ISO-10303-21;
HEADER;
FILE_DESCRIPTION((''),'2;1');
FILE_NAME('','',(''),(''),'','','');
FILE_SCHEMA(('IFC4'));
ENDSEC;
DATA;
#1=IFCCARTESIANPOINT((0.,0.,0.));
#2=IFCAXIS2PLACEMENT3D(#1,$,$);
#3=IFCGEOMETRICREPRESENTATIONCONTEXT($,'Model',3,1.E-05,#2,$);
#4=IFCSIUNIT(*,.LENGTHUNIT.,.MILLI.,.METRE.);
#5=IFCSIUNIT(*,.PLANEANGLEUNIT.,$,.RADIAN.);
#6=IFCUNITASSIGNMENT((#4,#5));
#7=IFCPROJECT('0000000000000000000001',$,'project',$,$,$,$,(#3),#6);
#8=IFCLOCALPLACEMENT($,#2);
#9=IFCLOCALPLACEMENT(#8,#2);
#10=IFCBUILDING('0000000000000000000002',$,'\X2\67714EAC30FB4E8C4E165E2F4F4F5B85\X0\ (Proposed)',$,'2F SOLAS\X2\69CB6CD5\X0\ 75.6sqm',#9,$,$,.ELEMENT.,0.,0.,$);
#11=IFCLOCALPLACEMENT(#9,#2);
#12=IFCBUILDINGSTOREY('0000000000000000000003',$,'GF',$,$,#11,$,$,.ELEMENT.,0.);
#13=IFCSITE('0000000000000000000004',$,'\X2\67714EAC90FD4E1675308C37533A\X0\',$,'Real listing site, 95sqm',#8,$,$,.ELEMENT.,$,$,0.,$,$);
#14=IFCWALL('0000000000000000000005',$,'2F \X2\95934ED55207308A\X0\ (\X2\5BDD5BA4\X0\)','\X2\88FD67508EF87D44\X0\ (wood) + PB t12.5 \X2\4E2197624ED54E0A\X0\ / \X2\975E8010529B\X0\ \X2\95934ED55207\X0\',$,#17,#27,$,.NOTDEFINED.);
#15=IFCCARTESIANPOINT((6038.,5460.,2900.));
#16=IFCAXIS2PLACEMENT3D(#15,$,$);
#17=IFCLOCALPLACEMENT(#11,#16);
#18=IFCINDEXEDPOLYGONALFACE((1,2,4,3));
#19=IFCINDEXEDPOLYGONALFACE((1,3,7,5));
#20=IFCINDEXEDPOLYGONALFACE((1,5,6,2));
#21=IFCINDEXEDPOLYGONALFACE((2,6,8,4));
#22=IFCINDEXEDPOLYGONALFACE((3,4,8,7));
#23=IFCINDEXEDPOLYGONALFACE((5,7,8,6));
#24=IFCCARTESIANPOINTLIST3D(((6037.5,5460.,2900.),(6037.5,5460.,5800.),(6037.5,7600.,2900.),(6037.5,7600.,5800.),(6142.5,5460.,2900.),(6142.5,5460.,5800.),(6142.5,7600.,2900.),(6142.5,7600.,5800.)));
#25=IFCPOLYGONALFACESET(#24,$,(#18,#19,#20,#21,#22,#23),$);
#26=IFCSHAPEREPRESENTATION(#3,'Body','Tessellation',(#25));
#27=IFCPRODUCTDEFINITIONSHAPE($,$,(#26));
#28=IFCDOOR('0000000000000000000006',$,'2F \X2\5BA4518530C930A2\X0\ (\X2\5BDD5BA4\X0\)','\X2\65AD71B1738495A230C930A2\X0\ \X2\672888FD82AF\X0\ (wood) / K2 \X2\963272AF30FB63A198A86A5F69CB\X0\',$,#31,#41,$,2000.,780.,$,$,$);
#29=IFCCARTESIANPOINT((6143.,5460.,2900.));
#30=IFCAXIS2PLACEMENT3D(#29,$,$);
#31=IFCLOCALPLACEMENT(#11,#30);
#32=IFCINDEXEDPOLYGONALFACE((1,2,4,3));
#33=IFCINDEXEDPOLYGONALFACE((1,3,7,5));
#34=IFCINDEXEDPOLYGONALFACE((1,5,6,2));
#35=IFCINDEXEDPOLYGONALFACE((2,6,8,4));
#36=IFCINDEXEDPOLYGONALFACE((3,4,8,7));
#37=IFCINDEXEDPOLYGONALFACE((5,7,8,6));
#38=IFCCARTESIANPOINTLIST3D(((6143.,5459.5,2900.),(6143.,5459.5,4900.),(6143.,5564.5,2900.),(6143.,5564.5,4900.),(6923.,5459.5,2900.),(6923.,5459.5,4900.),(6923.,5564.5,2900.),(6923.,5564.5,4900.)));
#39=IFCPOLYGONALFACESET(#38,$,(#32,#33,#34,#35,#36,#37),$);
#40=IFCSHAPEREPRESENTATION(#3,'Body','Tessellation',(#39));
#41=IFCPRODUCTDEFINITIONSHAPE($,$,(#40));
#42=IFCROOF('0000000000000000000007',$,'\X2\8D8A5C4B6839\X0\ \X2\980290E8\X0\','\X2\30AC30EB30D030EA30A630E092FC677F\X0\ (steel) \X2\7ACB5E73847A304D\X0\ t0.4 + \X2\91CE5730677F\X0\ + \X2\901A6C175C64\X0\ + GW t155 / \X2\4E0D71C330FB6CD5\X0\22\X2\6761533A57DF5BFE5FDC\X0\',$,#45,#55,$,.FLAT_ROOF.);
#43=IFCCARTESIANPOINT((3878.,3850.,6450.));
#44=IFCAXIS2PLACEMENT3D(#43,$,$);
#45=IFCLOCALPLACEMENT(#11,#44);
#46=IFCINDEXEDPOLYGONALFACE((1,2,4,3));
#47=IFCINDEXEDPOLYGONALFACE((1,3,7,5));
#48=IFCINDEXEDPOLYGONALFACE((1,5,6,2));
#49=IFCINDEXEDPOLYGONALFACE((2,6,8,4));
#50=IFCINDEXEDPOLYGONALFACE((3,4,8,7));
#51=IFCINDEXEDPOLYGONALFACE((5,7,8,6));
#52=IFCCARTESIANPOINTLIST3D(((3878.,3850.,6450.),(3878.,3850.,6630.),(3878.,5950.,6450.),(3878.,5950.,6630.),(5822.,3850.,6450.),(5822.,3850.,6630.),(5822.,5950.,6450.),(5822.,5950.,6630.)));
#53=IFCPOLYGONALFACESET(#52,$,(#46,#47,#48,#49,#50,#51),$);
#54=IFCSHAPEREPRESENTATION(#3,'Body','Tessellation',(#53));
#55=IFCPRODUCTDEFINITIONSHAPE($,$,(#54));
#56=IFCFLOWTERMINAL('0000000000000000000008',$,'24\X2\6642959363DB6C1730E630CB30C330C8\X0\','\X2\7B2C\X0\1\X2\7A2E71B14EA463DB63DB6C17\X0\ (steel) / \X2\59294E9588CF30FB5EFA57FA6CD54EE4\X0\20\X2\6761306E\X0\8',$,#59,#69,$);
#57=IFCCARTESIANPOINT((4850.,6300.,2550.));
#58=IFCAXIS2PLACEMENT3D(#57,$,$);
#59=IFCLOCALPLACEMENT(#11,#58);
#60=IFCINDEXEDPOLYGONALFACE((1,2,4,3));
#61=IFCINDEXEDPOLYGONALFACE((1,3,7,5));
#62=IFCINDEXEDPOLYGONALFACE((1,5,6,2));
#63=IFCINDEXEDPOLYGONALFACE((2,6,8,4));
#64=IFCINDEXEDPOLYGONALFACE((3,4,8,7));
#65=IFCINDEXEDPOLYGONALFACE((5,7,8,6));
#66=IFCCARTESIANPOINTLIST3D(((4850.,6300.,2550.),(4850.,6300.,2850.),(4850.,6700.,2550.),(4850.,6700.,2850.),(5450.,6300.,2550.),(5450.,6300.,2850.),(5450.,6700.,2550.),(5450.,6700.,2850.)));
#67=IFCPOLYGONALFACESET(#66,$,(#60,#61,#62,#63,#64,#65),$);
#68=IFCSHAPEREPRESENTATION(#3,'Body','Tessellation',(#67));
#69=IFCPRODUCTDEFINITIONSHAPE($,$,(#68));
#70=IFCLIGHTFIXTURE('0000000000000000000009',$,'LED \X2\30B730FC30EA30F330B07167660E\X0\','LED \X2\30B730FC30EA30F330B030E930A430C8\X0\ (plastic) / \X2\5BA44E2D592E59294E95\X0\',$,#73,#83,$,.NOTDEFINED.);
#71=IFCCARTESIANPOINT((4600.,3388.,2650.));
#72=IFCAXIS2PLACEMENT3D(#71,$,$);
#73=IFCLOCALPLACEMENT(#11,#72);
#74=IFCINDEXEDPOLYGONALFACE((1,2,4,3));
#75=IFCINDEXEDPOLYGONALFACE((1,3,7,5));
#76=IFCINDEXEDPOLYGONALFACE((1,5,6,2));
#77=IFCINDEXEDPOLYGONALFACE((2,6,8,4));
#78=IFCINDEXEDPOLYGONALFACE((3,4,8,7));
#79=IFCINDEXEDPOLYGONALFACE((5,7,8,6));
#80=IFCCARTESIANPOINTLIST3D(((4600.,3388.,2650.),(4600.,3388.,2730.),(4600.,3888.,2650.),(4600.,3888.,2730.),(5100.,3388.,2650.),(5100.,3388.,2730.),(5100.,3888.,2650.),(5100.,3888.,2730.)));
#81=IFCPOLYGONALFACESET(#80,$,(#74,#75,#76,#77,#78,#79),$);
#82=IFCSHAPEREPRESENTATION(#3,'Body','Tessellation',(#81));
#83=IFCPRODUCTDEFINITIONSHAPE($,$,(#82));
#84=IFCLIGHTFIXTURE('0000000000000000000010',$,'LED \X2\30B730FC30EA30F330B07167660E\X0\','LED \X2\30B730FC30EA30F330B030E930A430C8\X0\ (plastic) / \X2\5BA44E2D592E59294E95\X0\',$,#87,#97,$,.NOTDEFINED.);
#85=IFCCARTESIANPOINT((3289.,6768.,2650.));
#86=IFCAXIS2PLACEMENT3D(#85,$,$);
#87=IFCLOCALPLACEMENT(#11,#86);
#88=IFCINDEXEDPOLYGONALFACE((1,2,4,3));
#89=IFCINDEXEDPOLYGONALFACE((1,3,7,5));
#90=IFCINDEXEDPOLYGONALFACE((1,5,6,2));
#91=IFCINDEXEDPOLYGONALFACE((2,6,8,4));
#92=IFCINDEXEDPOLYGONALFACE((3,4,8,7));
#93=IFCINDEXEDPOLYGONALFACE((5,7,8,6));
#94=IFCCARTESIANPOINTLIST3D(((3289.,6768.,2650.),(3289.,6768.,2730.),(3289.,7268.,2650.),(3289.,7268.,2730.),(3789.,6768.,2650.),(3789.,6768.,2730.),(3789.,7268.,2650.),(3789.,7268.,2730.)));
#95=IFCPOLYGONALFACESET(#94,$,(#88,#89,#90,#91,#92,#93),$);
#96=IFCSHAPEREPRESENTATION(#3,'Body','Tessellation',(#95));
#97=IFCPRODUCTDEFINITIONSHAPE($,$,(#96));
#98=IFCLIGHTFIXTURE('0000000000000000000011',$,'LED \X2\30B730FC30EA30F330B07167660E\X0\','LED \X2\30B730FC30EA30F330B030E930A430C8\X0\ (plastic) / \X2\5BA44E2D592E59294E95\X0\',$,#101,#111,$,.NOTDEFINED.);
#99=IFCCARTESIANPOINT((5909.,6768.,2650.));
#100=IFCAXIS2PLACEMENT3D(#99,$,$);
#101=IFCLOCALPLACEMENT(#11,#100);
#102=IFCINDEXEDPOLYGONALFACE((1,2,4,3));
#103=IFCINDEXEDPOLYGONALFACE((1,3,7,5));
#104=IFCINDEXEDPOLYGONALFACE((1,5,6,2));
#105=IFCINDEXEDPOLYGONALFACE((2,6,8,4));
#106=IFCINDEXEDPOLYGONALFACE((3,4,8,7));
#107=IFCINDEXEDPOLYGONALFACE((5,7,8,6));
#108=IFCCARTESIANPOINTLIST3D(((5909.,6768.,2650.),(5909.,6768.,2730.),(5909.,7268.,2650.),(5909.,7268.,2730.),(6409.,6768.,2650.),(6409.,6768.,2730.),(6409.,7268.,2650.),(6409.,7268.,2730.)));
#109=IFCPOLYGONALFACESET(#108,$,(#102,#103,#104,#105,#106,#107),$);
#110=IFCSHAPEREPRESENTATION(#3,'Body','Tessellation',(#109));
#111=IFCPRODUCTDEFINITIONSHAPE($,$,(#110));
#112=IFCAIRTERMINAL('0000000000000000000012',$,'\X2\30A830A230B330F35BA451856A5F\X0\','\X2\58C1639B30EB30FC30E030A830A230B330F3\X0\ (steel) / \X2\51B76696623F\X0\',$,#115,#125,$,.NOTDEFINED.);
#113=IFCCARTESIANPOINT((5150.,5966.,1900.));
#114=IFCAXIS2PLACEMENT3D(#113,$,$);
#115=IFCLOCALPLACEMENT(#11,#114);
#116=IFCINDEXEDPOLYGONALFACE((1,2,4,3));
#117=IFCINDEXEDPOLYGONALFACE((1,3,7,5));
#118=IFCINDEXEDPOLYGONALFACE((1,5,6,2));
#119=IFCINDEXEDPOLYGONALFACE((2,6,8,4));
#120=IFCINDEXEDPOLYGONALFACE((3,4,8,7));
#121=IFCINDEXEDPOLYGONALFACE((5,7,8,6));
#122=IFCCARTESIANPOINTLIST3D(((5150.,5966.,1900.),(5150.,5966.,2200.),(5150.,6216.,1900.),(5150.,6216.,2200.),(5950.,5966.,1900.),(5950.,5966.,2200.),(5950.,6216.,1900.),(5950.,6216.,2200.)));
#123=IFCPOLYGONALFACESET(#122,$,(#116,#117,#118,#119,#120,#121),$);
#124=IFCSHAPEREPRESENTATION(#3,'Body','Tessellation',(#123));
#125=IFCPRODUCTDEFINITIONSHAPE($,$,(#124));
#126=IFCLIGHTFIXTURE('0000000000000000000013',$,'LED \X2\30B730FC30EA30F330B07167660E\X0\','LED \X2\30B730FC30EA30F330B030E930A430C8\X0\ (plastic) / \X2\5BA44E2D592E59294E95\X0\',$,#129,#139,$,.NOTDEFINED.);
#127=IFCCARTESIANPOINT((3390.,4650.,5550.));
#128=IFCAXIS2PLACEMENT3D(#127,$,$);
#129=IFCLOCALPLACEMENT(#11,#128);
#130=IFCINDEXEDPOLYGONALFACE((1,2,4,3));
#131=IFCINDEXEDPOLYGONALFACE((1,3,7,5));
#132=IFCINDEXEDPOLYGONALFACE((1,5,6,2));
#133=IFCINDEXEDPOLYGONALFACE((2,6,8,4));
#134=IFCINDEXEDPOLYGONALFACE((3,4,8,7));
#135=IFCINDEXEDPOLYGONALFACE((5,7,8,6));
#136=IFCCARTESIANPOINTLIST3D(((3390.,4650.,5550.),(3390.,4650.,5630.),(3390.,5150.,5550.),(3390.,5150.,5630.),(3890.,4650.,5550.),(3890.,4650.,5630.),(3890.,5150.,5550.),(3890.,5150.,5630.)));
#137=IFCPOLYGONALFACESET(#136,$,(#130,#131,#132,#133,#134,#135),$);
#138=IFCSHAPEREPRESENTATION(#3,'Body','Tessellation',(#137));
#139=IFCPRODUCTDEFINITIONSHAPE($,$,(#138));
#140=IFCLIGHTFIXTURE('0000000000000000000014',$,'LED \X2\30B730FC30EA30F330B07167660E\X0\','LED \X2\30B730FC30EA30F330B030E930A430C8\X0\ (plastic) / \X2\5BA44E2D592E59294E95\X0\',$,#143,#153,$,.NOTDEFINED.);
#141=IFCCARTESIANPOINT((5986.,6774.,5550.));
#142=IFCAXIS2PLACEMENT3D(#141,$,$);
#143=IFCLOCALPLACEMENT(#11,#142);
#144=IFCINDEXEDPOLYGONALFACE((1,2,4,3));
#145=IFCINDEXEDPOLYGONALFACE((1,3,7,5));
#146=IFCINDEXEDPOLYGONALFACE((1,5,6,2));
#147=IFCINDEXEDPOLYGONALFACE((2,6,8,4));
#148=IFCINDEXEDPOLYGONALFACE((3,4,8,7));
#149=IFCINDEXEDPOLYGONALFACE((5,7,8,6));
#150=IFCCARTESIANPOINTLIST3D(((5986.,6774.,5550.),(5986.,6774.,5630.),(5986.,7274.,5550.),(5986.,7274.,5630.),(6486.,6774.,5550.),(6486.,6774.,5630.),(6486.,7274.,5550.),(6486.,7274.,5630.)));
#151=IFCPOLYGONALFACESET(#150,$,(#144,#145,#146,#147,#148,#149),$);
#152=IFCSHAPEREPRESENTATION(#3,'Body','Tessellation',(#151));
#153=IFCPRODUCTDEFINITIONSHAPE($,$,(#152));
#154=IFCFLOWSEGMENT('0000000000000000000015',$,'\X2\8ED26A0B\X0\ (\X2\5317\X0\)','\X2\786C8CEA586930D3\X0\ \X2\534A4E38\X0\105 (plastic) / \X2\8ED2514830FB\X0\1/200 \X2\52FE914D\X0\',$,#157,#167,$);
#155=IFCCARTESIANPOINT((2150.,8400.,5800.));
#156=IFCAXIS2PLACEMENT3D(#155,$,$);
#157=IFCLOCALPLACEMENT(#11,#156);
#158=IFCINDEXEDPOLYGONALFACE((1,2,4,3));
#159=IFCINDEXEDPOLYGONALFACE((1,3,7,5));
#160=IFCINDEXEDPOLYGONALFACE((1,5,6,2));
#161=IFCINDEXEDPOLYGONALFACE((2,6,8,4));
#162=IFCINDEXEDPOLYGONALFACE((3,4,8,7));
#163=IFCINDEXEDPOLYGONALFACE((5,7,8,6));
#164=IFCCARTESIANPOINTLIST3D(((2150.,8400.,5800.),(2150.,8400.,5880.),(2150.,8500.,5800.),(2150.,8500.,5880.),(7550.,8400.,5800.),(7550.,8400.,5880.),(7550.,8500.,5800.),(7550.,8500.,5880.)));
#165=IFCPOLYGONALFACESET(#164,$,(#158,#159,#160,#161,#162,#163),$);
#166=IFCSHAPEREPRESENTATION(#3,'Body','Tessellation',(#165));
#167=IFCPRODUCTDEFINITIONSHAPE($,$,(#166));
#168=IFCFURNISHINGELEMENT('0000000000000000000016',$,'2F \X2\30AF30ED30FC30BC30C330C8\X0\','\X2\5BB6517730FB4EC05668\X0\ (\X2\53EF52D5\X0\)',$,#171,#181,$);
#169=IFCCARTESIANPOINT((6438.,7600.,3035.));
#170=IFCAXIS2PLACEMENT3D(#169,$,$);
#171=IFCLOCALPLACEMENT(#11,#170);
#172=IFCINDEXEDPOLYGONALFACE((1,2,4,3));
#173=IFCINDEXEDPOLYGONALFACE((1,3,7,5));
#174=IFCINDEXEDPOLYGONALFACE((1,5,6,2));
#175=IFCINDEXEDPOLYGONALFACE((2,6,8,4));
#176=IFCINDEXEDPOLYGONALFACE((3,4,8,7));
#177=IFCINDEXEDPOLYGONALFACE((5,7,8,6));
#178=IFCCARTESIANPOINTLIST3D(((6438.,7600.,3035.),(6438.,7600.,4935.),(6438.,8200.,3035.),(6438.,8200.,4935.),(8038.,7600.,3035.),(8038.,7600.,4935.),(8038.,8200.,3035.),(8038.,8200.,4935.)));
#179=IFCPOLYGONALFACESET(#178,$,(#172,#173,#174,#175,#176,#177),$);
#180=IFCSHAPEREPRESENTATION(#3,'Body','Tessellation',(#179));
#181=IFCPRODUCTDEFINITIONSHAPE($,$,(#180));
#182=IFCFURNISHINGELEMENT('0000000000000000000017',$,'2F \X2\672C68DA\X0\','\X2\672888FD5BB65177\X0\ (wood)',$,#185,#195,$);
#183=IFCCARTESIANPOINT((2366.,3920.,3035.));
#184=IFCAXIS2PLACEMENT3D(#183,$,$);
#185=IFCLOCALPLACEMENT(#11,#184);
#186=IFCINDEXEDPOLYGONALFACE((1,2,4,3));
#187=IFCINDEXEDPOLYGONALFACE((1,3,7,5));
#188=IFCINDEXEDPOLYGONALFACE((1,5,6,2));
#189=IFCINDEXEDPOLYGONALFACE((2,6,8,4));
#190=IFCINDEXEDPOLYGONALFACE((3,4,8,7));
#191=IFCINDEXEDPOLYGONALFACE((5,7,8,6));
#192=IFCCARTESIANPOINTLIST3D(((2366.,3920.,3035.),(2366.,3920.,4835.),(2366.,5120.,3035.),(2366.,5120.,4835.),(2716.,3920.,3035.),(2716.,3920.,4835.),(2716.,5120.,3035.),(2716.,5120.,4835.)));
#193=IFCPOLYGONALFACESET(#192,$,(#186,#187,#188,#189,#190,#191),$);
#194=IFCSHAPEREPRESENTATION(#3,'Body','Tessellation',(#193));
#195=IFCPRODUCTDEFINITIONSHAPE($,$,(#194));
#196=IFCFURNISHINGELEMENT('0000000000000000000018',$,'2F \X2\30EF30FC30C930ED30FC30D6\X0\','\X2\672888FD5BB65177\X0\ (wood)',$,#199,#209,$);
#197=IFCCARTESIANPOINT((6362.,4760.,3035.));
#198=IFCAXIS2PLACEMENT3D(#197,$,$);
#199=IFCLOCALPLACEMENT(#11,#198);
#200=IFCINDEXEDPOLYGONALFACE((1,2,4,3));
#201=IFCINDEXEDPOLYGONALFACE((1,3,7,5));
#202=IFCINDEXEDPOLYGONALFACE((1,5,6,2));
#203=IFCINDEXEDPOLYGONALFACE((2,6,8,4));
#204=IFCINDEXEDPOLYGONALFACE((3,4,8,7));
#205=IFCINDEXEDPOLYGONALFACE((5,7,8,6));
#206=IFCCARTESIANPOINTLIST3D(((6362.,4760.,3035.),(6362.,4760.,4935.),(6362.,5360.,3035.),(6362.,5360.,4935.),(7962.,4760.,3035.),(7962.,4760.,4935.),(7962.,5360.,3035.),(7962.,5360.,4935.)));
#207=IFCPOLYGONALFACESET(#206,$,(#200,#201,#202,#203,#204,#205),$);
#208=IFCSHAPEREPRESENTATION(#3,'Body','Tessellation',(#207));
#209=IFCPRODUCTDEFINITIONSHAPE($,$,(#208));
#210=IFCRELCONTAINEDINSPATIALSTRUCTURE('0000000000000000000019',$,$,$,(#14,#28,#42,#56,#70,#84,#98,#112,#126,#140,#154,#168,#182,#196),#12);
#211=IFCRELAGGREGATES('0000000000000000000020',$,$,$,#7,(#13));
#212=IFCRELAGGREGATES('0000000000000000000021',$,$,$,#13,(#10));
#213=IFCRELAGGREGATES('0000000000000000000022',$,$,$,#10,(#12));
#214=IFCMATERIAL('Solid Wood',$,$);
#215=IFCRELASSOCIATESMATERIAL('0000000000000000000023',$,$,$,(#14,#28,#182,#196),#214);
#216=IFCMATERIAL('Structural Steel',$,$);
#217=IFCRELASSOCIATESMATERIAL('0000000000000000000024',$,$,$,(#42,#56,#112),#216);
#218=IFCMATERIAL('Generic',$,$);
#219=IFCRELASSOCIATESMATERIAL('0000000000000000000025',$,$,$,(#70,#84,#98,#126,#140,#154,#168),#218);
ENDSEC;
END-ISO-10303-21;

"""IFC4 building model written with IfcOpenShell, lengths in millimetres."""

from ifc_helpers import new_model, si_unit, frame, frame_2d, origin, place, context, project, spatial, rectangle, extrude, material, element, save


model = new_model("IFC4")

# Units and contexts
model_context = context("Model", 3, precision=1e-05, world=origin())
ifc_project = project(units=[si_unit("LENGTHUNIT", "METRE", prefix="MILLI"), si_unit("PLANEANGLEUNIT", "RADIAN")], contexts=[model_context])

# Site, building, storey
site_placement = place(None, origin())
site = spatial("IfcSite", under=ifc_project, at=site_placement, Name="東京都世田谷区", ObjectType="Real listing site, 95sqm", CompositionType="ELEMENT", RefElevation=0.0)
building_placement = place(site_placement, origin())
building = spatial("IfcBuilding", under=site, at=building_placement, Name="東京・二世帯住宅 (Proposed)", ObjectType="2F SOLAS構法 75.6sqm", CompositionType="ELEMENT", ElevationOfRefHeight=0.0, ElevationOfTerrain=0.0)
storey_placement = place(building_placement, origin())
storey = spatial("IfcBuildingStorey", under=building, at=storey_placement, Name="GF", CompositionType="ELEMENT", Elevation=0.0)

# Shared definitions
ifc_material_1 = material(Name="Solid Wood")

# Wall
wall_1_placement = place(storey_placement, frame((6038.0, 5460.0, 2900.0)))
element("IfcWall", 1, at=wall_1_placement, inside=storey, material=ifc_material_1, Name="2F 間仕切り (寝室)", Description="製材軸組 (wood) + PB t12.5 両面仕上 / 非耐力 間仕切", PredefinedType="NOTDEFINED", context=model_context, shape_type="SweptSolid", body=[
    extrude(rectangle(XDim=105.0, YDim=2140.0, at=frame_2d((52.0, 1070.0))), frame((6038.0, 5460.0, 2900.0)), (0.0, 0.0, 1.0), 2900.0),
])

# Door
door_placement = place(storey_placement, frame((6143.0, 5460.0, 2900.0)))
element("IfcDoor", 2, at=door_placement, inside=storey, material=ifc_material_1, Name="2F 室内ドア (寝室)", Description="断熱玄関ドア 木製芯 (wood) / K2 防犯・採風機構", OverallHeight=2000.0, OverallWidth=780.0, context=model_context, shape_type="SweptSolid", body=[
    extrude(rectangle(XDim=780.0, YDim=105.0, at=frame_2d((390.0, 52.0))), frame((6143.0, 5460.0, 2900.0)), (0.0, 0.0, 1.0), 2000.0),
])

# Roof
ifc_material_2 = material(Name="Structural Steel")
roof_placement = place(storey_placement, frame((3878.0, 3850.0, 6450.0)))
element("IfcRoof", 3, at=roof_placement, inside=storey, material=ifc_material_2, Name="越屋根 頂部", Description="ガルバリウム鋼板 (steel) 立平葺き t0.4 + 野地板 + 通気層 + GW t155 / 不燃・法22条区域対応", PredefinedType="FLAT_ROOF", context=model_context, shape_type="SweptSolid", body=[
    extrude(rectangle(XDim=1944.0, YDim=2100.0, at=frame_2d((972.0, 1050.0))), frame((3878.0, 3850.0, 6450.0)), (0.0, 0.0, 1.0), 180.0),
])

# Flow terminal
flow_terminal_placement = place(storey_placement, frame((4850.0, 6300.0, 2550.0)))
element("IfcFlowTerminal", 4, at=flow_terminal_placement, inside=storey, material=ifc_material_2, Name="24時間換気ユニット", Description="第1種熱交換換気 (steel) / 天井裏・建基法令20条の8", context=model_context, shape_type="SweptSolid", body=[
    extrude(rectangle(XDim=600.0, YDim=400.0, at=frame_2d((300.0, 200.0))), frame((4850.0, 6300.0, 2550.0)), (0.0, 0.0, 1.0), 300.0),
])

# Light fixtures
ifc_material_3 = material(Name="Generic")
light_fixture_1_placement = place(storey_placement, frame((4600.0, 3388.0, 2650.0)))
element("IfcLightFixture", 5, at=light_fixture_1_placement, inside=storey, material=ifc_material_3, Name="LED シーリング照明", Description="LED シーリングライト (plastic) / 室中央天井", PredefinedType="NOTDEFINED", context=model_context, shape_type="SweptSolid", body=[
    extrude(rectangle(XDim=500.0, YDim=500.0, at=frame_2d((250.0, 250.0))), frame((4600.0, 3388.0, 2650.0)), (0.0, 0.0, 1.0), 80.0),
])
light_fixture_2_placement = place(storey_placement, frame((3289.0, 6768.0, 2650.0)))
element("IfcLightFixture", 6, at=light_fixture_2_placement, inside=storey, material=ifc_material_3, Name="LED シーリング照明", Description="LED シーリングライト (plastic) / 室中央天井", PredefinedType="NOTDEFINED", context=model_context, shape_type="SweptSolid", body=[
    extrude(rectangle(XDim=500.0, YDim=500.0, at=frame_2d((250.0, 250.0))), frame((3289.0, 6768.0, 2650.0)), (0.0, 0.0, 1.0), 80.0),
])
light_fixture_3_placement = place(storey_placement, frame((5909.0, 6768.0, 2650.0)))
element("IfcLightFixture", 7, at=light_fixture_3_placement, inside=storey, material=ifc_material_3, Name="LED シーリング照明", Description="LED シーリングライト (plastic) / 室中央天井", PredefinedType="NOTDEFINED", context=model_context, shape_type="SweptSolid", body=[
    extrude(rectangle(XDim=500.0, YDim=500.0, at=frame_2d((250.0, 250.0))), frame((5909.0, 6768.0, 2650.0)), (0.0, 0.0, 1.0), 80.0),
])

# Air terminal
air_terminal_placement = place(storey_placement, frame((5150.0, 5966.0, 1900.0)))
element("IfcAirTerminal", 8, at=air_terminal_placement, inside=storey, material=ifc_material_2, Name="エアコン室内機", Description="壁掛ルームエアコン (steel) / 冷暖房", PredefinedType="NOTDEFINED", context=model_context, shape_type="SweptSolid", body=[
    extrude(rectangle(XDim=800.0, YDim=250.0, at=frame_2d((400.0, 125.0))), frame((5150.0, 5966.0, 1900.0)), (0.0, 0.0, 1.0), 300.0),
])

# Light fixtures
light_fixture_4_placement = place(storey_placement, frame((3390.0, 4650.0, 5550.0)))
element("IfcLightFixture", 9, at=light_fixture_4_placement, inside=storey, material=ifc_material_3, Name="LED シーリング照明", Description="LED シーリングライト (plastic) / 室中央天井", PredefinedType="NOTDEFINED", context=model_context, shape_type="SweptSolid", body=[
    extrude(rectangle(XDim=500.0, YDim=500.0, at=frame_2d((250.0, 250.0))), frame((3390.0, 4650.0, 5550.0)), (0.0, 0.0, 1.0), 80.0),
])
light_fixture_5_placement = place(storey_placement, frame((5986.0, 6774.0, 5550.0)))
element("IfcLightFixture", 10, at=light_fixture_5_placement, inside=storey, material=ifc_material_3, Name="LED シーリング照明", Description="LED シーリングライト (plastic) / 室中央天井", PredefinedType="NOTDEFINED", context=model_context, shape_type="SweptSolid", body=[
    extrude(rectangle(XDim=500.0, YDim=500.0, at=frame_2d((250.0, 250.0))), frame((5986.0, 6774.0, 5550.0)), (0.0, 0.0, 1.0), 80.0),
])

# Flow segment
flow_segment_placement = place(storey_placement, frame((2150.0, 8400.0, 5800.0)))
element("IfcFlowSegment", 11, at=flow_segment_placement, inside=storey, material=ifc_material_3, Name="軒樋 (北)", Description="硬質塩ビ 半丸105 (plastic) / 軒先・1/200 勾配", context=model_context, shape_type="SweptSolid", body=[
    extrude(rectangle(XDim=5400.0, YDim=100.0, at=frame_2d((2700.0, 50.0))), frame((2150.0, 8400.0, 5800.0)), (0.0, 0.0, 1.0), 80.0),
])

# Furnishing elements
furnishing_1_placement = place(storey_placement, frame((6438.0, 7600.0, 3035.0)))
element("IfcFurnishingElement", 12, at=furnishing_1_placement, inside=storey, material=ifc_material_3, Name="2F クローゼット", Description="家具・什器 (可動)", context=model_context, shape_type="SweptSolid", body=[
    extrude(rectangle(XDim=1600.0, YDim=600.0, at=frame_2d((800.0, 300.0))), frame((6438.0, 7600.0, 3035.0)), (0.0, 0.0, 1.0), 1900.0),
])
furnishing_2_placement = place(storey_placement, frame((2366.0, 3920.0, 3035.0)))
element("IfcFurnishingElement", 13, at=furnishing_2_placement, inside=storey, material=ifc_material_1, Name="2F 本棚", Description="木製家具 (wood)", context=model_context, shape_type="SweptSolid", body=[
    extrude(rectangle(XDim=350.0, YDim=1200.0, at=frame_2d((175.0, 600.0))), frame((2366.0, 3920.0, 3035.0)), (0.0, 0.0, 1.0), 1800.0),
])
furnishing_3_placement = place(storey_placement, frame((6362.0, 4760.0, 3035.0)))
element("IfcFurnishingElement", 14, at=furnishing_3_placement, inside=storey, material=ifc_material_1, Name="2F ワードローブ", Description="木製家具 (wood)", context=model_context, shape_type="SweptSolid", body=[
    extrude(rectangle(XDim=1600.0, YDim=600.0, at=frame_2d((800.0, 300.0))), frame((6362.0, 4760.0, 3035.0)), (0.0, 0.0, 1.0), 1900.0),
])

save(model, "model.ifc")
